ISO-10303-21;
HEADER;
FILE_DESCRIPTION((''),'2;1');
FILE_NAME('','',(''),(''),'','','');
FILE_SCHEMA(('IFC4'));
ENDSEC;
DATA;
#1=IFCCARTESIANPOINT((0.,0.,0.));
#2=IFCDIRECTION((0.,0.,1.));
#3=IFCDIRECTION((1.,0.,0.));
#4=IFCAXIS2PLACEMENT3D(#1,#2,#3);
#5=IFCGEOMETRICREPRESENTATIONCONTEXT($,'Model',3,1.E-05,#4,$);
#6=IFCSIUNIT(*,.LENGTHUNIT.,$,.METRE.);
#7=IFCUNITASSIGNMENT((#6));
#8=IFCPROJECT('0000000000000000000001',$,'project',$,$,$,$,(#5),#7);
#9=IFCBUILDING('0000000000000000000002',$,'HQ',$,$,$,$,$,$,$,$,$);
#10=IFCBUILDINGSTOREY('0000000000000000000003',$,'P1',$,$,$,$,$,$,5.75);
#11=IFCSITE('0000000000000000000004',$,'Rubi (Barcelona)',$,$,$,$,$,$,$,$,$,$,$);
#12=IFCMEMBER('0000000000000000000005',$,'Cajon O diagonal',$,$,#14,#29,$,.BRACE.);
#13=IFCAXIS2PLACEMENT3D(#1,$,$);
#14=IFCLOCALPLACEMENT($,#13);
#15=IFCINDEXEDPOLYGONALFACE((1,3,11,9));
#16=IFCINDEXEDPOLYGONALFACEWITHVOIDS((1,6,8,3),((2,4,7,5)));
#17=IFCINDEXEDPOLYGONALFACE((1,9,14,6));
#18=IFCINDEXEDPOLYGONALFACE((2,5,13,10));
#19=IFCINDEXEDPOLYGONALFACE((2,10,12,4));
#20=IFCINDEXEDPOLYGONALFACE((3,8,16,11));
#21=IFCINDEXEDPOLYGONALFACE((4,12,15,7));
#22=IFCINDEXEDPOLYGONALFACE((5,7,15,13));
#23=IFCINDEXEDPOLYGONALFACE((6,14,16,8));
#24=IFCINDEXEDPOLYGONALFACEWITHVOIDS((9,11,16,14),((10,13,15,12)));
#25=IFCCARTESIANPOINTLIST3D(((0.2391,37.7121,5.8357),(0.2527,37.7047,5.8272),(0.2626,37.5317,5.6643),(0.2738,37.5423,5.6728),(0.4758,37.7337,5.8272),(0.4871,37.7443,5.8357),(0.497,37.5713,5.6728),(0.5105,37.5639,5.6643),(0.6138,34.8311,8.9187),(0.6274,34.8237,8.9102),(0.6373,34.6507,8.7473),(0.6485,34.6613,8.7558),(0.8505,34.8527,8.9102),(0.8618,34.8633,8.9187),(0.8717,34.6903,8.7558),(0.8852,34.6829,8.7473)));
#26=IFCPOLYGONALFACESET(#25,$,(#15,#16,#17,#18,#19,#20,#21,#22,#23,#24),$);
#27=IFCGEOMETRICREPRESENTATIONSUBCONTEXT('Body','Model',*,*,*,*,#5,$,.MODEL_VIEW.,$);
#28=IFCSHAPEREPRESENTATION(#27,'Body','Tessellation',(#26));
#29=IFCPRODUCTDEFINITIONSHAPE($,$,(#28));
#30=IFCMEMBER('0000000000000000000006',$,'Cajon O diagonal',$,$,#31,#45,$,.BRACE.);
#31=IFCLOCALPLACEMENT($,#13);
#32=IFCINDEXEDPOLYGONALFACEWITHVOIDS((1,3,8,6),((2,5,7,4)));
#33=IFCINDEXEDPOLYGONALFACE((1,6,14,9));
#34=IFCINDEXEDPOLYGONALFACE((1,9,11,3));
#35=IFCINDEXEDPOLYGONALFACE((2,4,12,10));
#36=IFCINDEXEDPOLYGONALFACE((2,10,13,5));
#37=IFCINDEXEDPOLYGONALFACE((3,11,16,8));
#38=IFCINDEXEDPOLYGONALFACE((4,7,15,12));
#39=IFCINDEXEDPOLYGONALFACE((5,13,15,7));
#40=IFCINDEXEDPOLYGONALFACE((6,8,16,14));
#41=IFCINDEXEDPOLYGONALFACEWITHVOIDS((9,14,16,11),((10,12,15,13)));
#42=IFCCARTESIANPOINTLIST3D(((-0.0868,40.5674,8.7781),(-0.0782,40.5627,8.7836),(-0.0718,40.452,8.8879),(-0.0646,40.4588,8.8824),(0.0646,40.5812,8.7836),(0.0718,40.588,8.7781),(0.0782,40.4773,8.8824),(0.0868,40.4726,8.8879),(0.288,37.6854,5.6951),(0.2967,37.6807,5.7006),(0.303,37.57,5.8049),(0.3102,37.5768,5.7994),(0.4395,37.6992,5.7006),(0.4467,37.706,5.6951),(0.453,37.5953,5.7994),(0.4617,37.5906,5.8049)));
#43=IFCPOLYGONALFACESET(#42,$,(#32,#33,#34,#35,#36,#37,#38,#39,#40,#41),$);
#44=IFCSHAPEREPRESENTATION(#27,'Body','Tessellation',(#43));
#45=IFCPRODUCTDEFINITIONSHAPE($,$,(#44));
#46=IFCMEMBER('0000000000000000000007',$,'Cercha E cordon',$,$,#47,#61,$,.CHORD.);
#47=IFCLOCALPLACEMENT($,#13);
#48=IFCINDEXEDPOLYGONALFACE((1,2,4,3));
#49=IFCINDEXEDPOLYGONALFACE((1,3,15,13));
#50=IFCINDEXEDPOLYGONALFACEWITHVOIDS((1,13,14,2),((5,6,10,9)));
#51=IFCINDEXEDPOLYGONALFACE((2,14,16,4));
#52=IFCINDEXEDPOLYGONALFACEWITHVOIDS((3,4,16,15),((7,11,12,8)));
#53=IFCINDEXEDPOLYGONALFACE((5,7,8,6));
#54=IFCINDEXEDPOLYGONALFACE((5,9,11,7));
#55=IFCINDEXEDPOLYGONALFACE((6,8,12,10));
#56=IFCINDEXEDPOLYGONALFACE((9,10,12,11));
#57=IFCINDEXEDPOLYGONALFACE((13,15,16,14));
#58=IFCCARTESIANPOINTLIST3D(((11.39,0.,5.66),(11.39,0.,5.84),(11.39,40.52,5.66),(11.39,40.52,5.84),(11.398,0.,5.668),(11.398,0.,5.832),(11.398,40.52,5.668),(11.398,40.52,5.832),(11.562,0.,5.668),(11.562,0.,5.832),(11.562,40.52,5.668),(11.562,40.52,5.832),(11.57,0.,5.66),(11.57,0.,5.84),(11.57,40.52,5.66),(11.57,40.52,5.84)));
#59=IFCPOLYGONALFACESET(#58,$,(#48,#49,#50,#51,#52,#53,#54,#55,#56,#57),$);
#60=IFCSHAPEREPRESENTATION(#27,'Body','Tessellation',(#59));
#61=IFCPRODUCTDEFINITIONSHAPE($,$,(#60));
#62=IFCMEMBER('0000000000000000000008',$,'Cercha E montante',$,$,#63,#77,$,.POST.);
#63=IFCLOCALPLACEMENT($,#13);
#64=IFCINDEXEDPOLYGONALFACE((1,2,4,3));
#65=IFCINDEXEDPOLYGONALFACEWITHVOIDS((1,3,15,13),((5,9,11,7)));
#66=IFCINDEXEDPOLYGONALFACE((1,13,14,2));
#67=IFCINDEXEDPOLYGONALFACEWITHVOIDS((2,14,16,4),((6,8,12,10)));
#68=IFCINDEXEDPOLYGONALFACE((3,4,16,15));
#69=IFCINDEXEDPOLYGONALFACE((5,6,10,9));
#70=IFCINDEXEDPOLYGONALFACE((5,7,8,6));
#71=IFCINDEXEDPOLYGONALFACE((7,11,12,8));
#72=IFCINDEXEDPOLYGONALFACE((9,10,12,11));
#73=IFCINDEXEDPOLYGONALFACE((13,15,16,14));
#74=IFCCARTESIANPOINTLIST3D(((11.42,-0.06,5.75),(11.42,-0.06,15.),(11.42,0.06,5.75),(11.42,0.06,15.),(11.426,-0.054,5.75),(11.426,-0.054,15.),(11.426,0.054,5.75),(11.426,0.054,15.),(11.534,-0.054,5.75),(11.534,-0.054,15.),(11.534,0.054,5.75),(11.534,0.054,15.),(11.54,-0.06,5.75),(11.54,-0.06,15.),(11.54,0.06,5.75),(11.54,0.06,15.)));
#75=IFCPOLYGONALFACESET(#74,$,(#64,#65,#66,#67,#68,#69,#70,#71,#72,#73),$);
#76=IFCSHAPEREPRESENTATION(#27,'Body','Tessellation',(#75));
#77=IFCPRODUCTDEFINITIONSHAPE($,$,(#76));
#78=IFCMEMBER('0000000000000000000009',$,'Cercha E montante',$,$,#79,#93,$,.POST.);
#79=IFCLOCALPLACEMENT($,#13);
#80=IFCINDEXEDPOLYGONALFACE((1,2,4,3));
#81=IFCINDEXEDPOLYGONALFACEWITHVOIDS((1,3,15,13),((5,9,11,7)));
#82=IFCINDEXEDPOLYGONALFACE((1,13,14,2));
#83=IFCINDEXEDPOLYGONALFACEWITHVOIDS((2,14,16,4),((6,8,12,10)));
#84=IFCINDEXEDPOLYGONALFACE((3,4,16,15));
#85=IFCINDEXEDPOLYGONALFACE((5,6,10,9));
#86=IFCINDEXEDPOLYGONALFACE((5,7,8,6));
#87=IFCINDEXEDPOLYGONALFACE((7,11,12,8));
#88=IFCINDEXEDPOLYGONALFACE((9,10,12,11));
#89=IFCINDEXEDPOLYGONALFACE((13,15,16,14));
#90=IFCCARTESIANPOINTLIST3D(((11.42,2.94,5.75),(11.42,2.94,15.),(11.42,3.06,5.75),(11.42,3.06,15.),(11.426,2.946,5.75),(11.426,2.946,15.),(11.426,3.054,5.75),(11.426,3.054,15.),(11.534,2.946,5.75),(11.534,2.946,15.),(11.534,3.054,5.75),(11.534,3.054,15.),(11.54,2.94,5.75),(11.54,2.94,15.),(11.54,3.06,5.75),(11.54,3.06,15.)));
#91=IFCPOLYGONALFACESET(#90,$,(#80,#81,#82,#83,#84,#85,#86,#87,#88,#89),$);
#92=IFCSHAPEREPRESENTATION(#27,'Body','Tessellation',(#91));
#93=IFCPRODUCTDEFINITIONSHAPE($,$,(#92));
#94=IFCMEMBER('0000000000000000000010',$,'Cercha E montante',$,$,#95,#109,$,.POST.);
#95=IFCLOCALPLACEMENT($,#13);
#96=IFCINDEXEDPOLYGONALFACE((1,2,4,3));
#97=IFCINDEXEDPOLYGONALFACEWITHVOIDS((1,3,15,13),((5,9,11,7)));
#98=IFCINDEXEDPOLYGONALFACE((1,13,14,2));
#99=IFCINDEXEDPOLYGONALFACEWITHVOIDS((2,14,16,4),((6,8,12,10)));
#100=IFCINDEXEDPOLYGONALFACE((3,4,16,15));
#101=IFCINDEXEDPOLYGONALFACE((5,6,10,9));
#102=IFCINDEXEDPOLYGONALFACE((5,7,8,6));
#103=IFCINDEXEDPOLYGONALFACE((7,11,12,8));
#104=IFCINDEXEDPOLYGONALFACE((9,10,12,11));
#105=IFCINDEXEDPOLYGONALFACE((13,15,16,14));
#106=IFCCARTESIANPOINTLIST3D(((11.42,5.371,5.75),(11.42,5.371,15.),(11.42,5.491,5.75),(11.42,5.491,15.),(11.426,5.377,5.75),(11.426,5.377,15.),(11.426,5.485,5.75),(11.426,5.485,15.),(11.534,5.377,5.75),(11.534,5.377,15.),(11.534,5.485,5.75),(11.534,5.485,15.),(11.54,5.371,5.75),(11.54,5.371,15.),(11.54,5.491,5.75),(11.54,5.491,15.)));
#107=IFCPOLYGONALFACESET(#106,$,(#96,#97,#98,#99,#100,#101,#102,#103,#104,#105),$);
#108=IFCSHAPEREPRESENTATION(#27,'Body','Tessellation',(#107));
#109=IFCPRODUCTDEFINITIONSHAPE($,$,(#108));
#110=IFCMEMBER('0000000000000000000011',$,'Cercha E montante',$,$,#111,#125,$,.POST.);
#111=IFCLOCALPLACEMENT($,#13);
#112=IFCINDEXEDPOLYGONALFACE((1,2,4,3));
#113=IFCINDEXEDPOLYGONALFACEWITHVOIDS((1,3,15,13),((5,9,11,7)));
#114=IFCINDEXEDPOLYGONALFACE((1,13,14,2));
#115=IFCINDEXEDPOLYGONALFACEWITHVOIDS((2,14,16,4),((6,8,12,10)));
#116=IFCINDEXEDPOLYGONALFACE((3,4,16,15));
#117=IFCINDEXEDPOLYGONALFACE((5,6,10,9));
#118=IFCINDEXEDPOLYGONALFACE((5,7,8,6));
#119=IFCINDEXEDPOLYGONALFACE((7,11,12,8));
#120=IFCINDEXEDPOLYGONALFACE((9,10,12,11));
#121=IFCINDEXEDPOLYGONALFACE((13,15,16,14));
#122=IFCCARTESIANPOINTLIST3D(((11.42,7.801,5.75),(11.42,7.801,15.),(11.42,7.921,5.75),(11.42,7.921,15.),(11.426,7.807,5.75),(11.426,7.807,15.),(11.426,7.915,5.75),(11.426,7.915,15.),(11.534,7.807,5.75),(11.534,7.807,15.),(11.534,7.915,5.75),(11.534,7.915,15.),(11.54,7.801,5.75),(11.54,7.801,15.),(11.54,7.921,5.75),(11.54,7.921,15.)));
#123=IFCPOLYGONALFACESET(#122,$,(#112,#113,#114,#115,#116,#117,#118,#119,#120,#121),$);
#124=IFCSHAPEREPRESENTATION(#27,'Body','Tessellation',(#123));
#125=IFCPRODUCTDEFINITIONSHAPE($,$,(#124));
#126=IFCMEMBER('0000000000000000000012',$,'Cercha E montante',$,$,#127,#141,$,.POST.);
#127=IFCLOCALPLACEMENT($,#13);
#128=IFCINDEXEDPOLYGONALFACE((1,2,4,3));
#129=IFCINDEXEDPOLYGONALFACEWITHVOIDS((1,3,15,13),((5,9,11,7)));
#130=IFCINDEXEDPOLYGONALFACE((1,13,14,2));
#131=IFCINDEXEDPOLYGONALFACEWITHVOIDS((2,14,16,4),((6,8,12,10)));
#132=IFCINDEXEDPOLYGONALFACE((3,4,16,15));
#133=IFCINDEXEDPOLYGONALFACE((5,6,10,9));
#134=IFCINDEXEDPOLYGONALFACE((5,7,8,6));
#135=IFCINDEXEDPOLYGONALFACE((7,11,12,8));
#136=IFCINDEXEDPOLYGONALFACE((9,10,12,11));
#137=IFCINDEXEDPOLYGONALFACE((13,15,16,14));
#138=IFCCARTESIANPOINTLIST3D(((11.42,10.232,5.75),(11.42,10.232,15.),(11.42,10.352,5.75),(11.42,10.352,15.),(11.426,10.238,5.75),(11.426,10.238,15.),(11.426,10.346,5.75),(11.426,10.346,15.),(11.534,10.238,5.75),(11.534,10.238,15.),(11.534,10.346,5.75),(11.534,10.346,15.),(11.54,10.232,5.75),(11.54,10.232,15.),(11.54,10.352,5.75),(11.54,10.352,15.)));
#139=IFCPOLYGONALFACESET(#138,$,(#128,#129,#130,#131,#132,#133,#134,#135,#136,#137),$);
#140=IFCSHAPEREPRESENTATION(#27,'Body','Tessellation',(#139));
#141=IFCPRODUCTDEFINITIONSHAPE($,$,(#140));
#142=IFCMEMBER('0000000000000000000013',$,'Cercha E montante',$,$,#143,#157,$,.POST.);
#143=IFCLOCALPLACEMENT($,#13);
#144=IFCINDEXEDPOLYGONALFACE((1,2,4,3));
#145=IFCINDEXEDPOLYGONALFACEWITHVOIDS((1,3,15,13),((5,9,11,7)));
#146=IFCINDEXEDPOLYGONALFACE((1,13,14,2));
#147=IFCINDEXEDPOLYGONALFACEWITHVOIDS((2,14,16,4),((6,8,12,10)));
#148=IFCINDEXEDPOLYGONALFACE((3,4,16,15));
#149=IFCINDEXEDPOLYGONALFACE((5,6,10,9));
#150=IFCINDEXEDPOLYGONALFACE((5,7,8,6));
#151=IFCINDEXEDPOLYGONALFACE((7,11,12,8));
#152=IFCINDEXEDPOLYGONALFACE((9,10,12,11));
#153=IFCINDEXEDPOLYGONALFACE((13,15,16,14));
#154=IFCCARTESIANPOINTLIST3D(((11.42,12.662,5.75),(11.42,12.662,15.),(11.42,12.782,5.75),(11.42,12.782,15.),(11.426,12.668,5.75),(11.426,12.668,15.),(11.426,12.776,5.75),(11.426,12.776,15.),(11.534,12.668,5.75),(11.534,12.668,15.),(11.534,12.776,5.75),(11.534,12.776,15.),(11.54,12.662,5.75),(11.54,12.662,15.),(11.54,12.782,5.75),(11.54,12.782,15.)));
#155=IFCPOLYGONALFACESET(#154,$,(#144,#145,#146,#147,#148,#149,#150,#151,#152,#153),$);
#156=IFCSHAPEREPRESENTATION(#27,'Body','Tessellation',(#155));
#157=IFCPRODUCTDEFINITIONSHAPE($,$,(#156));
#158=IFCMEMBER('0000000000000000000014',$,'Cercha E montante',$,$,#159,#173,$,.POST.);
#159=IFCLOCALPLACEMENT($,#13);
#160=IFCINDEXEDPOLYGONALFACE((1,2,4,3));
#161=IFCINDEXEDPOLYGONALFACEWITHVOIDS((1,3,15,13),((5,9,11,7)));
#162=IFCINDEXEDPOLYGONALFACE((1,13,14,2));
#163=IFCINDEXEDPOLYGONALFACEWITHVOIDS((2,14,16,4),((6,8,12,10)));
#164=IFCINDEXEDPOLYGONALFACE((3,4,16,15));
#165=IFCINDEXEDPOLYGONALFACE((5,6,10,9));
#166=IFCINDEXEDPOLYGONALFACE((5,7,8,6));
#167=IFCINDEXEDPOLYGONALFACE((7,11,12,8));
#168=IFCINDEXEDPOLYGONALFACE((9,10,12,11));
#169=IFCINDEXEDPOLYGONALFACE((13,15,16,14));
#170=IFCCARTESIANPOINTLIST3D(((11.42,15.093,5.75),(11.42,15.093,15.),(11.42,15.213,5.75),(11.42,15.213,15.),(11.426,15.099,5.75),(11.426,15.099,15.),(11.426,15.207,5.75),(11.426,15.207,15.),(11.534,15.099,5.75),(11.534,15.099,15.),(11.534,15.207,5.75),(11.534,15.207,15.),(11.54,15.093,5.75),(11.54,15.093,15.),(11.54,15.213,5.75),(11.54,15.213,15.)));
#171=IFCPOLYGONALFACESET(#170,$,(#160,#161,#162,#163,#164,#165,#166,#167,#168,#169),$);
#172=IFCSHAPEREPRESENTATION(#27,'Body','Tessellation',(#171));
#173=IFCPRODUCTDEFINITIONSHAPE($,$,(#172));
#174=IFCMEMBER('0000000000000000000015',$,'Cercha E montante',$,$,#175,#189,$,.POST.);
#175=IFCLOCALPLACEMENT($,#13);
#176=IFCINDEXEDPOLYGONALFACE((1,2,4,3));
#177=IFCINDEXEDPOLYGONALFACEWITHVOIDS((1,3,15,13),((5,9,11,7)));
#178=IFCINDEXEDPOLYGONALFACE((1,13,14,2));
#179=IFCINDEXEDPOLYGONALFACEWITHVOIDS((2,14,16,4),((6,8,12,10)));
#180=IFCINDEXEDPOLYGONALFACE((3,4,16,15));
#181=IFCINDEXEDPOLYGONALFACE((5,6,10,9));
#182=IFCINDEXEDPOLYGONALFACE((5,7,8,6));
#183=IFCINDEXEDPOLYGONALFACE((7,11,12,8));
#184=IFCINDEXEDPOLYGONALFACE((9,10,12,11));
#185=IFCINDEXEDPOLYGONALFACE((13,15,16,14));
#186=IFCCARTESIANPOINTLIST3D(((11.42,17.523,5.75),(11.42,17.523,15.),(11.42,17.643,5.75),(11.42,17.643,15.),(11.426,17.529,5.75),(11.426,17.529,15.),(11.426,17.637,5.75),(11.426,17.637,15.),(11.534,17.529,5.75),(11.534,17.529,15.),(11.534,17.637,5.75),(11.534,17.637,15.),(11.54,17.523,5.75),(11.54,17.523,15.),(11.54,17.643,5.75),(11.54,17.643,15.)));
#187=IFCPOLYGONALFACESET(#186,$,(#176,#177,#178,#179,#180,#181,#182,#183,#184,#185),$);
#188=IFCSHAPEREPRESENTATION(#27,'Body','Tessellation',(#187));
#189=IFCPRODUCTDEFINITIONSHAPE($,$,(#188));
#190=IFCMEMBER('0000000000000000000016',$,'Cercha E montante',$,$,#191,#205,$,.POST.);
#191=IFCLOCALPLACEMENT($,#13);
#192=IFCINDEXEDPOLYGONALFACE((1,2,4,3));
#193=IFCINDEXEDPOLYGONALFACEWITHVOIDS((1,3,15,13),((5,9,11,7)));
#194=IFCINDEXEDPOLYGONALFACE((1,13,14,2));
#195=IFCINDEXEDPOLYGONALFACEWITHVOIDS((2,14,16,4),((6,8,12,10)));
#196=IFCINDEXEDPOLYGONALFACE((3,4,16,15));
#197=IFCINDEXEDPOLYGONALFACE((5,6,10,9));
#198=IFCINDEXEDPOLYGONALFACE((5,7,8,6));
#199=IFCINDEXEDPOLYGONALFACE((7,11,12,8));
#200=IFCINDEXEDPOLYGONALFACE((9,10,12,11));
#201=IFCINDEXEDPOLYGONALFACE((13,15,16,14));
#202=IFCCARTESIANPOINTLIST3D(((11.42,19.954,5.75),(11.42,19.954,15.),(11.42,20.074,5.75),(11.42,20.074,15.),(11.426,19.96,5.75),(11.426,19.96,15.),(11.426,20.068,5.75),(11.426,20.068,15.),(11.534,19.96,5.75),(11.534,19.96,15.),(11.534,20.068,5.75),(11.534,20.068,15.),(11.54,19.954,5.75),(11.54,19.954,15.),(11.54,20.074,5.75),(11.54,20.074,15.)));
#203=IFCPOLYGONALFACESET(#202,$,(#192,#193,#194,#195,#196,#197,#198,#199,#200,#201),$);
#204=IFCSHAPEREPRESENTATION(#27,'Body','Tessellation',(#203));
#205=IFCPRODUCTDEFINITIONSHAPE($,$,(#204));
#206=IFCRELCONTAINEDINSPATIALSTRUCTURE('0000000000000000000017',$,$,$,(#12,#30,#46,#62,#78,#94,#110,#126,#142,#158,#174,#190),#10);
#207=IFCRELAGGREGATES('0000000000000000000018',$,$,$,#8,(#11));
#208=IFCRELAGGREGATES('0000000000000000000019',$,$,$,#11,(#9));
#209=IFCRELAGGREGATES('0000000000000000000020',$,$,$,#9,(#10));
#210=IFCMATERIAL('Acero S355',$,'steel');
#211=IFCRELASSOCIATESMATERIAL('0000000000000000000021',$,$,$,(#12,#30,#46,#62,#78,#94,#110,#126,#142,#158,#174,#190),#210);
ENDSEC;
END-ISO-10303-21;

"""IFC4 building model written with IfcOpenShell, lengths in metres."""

from ifc_helpers import new_model, si_unit, frame, origin_with_axes, place, context, subcontext, project, spatial, hollow_rectangle, extrude, material, element, save


model = new_model("IFC4")

# Units and contexts
model_context = context("Model", 3, precision=1e-05, world=origin_with_axes())
body_context = subcontext(model_context, "Body", "Model", "MODEL_VIEW")
ifc_project = project(units=[si_unit("LENGTHUNIT", "METRE")], contexts=[model_context])

# Site, building, storey
site = spatial("IfcSite", under=ifc_project, Name="Rubi (Barcelona)")
building = spatial("IfcBuilding", under=site, Name="HQ")
storey = spatial("IfcBuildingStorey", under=building, Name="P1", Elevation=5.75)

# Members
ifc_material = material(Name="Acero S355", Category="steel")
member_1_placement = place(None, origin_with_axes())
element("IfcMember", 1, at=member_1_placement, inside=storey, material=ifc_material, Name="Cajon O diagonal", PredefinedType="BRACE", context=body_context, shape_type="SweptSolid", body=[
    extrude(hollow_rectangle(XDim=0.25, YDim=0.25, WallThickness=0.0125), frame((0.3748, 37.638, 5.75), z_axis=(0.088452, -0.68009, 0.727774), x_axis=(0.991648, 0.128973, 0.0)), (0.0, 0.0, 1.0), 4.2362),
])
member_2_placement = place(None, origin_with_axes())
element("IfcMember", 2, at=member_2_placement, inside=storey, material=ifc_material, Name="Cajon O diagonal", PredefinedType="BRACE", context=body_context, shape_type="SweptSolid", body=[
    extrude(hollow_rectangle(XDim=0.16, YDim=0.16, WallThickness=0.008), frame((0.3748, 37.638, 5.75), z_axis=(-0.088468, 0.680215, 0.727655), x_axis=(-0.991648, -0.128973, 0.0)), (0.0, 0.0, 1.0), 4.2369),
])
member_3_placement = place(None, origin_with_axes())
element("IfcMember", 3, at=member_3_placement, inside=storey, material=ifc_material, Name="Cercha E cordon", PredefinedType="CHORD", context=body_context, shape_type="SweptSolid", body=[
    extrude(hollow_rectangle(XDim=0.18, YDim=0.18, WallThickness=0.008), frame((11.48, 0.0, 5.75), z_axis=(0.0, 1.0, 0.0), x_axis=(-1.0, 0.0, 0.0)), (0.0, 0.0, 1.0), 40.52),
])
member_4_placement = place(None, origin_with_axes())
element("IfcMember", 4, at=member_4_placement, inside=storey, material=ifc_material, Name="Cercha E montante", PredefinedType="POST", context=body_context, shape_type="SweptSolid", body=[
    extrude(hollow_rectangle(XDim=0.12, YDim=0.12, WallThickness=0.006), frame((11.48, 0.0, 5.75), z_axis=(0.0, 0.0, 1.0), x_axis=(1.0, 0.0, 0.0)), (0.0, 0.0, 1.0), 9.25),
])
member_5_placement = place(None, origin_with_axes())
element("IfcMember", 5, at=member_5_placement, inside=storey, material=ifc_material, Name="Cercha E montante", PredefinedType="POST", context=body_context, shape_type="SweptSolid", body=[
    extrude(hollow_rectangle(XDim=0.12, YDim=0.12, WallThickness=0.006), frame((11.48, 3.0, 5.75), z_axis=(0.0, 0.0, 1.0), x_axis=(1.0, 0.0, 0.0)), (0.0, 0.0, 1.0), 9.25),
])
member_6_placement = place(None, origin_with_axes())
element("IfcMember", 6, at=member_6_placement, inside=storey, material=ifc_material, Name="Cercha E montante", PredefinedType="POST", context=body_context, shape_type="SweptSolid", body=[
    extrude(hollow_rectangle(XDim=0.12, YDim=0.12, WallThickness=0.006), frame((11.48, 5.431, 5.75), z_axis=(0.0, 0.0, 1.0), x_axis=(1.0, 0.0, 0.0)), (0.0, 0.0, 1.0), 9.25),
])
member_7_placement = place(None, origin_with_axes())
element("IfcMember", 7, at=member_7_placement, inside=storey, material=ifc_material, Name="Cercha E montante", PredefinedType="POST", context=body_context, shape_type="SweptSolid", body=[
    extrude(hollow_rectangle(XDim=0.12, YDim=0.12, WallThickness=0.006), frame((11.48, 7.861, 5.75), z_axis=(0.0, 0.0, 1.0), x_axis=(1.0, 0.0, 0.0)), (0.0, 0.0, 1.0), 9.25),
])
member_8_placement = place(None, origin_with_axes())
element("IfcMember", 8, at=member_8_placement, inside=storey, material=ifc_material, Name="Cercha E montante", PredefinedType="POST", context=body_context, shape_type="SweptSolid", body=[
    extrude(hollow_rectangle(XDim=0.12, YDim=0.12, WallThickness=0.006), frame((11.48, 10.292, 5.75), z_axis=(0.0, 0.0, 1.0), x_axis=(1.0, 0.0, 0.0)), (0.0, 0.0, 1.0), 9.25),
])
member_9_placement = place(None, origin_with_axes())
element("IfcMember", 9, at=member_9_placement, inside=storey, material=ifc_material, Name="Cercha E montante", PredefinedType="POST", context=body_context, shape_type="SweptSolid", body=[
    extrude(hollow_rectangle(XDim=0.12, YDim=0.12, WallThickness=0.006), frame((11.48, 12.722, 5.75), z_axis=(0.0, 0.0, 1.0), x_axis=(1.0, 0.0, 0.0)), (0.0, 0.0, 1.0), 9.25),
])
member_10_placement = place(None, origin_with_axes())
element("IfcMember", 10, at=member_10_placement, inside=storey, material=ifc_material, Name="Cercha E montante", PredefinedType="POST", context=body_context, shape_type="SweptSolid", body=[
    extrude(hollow_rectangle(XDim=0.12, YDim=0.12, WallThickness=0.006), frame((11.48, 15.153, 5.75), z_axis=(0.0, 0.0, 1.0), x_axis=(1.0, 0.0, 0.0)), (0.0, 0.0, 1.0), 9.25),
])
member_11_placement = place(None, origin_with_axes())
element("IfcMember", 11, at=member_11_placement, inside=storey, material=ifc_material, Name="Cercha E montante", PredefinedType="POST", context=body_context, shape_type="SweptSolid", body=[
    extrude(hollow_rectangle(XDim=0.12, YDim=0.12, WallThickness=0.006), frame((11.48, 17.583, 5.75), z_axis=(0.0, 0.0, 1.0), x_axis=(1.0, 0.0, 0.0)), (0.0, 0.0, 1.0), 9.25),
])
member_12_placement = place(None, origin_with_axes())
element("IfcMember", 12, at=member_12_placement, inside=storey, material=ifc_material, Name="Cercha E montante", PredefinedType="POST", context=body_context, shape_type="SweptSolid", body=[
    extrude(hollow_rectangle(XDim=0.12, YDim=0.12, WallThickness=0.006), frame((11.48, 20.014, 5.75), z_axis=(0.0, 0.0, 1.0), x_axis=(1.0, 0.0, 0.0)), (0.0, 0.0, 1.0), 9.25),
])

save(model, "model.ifc")
